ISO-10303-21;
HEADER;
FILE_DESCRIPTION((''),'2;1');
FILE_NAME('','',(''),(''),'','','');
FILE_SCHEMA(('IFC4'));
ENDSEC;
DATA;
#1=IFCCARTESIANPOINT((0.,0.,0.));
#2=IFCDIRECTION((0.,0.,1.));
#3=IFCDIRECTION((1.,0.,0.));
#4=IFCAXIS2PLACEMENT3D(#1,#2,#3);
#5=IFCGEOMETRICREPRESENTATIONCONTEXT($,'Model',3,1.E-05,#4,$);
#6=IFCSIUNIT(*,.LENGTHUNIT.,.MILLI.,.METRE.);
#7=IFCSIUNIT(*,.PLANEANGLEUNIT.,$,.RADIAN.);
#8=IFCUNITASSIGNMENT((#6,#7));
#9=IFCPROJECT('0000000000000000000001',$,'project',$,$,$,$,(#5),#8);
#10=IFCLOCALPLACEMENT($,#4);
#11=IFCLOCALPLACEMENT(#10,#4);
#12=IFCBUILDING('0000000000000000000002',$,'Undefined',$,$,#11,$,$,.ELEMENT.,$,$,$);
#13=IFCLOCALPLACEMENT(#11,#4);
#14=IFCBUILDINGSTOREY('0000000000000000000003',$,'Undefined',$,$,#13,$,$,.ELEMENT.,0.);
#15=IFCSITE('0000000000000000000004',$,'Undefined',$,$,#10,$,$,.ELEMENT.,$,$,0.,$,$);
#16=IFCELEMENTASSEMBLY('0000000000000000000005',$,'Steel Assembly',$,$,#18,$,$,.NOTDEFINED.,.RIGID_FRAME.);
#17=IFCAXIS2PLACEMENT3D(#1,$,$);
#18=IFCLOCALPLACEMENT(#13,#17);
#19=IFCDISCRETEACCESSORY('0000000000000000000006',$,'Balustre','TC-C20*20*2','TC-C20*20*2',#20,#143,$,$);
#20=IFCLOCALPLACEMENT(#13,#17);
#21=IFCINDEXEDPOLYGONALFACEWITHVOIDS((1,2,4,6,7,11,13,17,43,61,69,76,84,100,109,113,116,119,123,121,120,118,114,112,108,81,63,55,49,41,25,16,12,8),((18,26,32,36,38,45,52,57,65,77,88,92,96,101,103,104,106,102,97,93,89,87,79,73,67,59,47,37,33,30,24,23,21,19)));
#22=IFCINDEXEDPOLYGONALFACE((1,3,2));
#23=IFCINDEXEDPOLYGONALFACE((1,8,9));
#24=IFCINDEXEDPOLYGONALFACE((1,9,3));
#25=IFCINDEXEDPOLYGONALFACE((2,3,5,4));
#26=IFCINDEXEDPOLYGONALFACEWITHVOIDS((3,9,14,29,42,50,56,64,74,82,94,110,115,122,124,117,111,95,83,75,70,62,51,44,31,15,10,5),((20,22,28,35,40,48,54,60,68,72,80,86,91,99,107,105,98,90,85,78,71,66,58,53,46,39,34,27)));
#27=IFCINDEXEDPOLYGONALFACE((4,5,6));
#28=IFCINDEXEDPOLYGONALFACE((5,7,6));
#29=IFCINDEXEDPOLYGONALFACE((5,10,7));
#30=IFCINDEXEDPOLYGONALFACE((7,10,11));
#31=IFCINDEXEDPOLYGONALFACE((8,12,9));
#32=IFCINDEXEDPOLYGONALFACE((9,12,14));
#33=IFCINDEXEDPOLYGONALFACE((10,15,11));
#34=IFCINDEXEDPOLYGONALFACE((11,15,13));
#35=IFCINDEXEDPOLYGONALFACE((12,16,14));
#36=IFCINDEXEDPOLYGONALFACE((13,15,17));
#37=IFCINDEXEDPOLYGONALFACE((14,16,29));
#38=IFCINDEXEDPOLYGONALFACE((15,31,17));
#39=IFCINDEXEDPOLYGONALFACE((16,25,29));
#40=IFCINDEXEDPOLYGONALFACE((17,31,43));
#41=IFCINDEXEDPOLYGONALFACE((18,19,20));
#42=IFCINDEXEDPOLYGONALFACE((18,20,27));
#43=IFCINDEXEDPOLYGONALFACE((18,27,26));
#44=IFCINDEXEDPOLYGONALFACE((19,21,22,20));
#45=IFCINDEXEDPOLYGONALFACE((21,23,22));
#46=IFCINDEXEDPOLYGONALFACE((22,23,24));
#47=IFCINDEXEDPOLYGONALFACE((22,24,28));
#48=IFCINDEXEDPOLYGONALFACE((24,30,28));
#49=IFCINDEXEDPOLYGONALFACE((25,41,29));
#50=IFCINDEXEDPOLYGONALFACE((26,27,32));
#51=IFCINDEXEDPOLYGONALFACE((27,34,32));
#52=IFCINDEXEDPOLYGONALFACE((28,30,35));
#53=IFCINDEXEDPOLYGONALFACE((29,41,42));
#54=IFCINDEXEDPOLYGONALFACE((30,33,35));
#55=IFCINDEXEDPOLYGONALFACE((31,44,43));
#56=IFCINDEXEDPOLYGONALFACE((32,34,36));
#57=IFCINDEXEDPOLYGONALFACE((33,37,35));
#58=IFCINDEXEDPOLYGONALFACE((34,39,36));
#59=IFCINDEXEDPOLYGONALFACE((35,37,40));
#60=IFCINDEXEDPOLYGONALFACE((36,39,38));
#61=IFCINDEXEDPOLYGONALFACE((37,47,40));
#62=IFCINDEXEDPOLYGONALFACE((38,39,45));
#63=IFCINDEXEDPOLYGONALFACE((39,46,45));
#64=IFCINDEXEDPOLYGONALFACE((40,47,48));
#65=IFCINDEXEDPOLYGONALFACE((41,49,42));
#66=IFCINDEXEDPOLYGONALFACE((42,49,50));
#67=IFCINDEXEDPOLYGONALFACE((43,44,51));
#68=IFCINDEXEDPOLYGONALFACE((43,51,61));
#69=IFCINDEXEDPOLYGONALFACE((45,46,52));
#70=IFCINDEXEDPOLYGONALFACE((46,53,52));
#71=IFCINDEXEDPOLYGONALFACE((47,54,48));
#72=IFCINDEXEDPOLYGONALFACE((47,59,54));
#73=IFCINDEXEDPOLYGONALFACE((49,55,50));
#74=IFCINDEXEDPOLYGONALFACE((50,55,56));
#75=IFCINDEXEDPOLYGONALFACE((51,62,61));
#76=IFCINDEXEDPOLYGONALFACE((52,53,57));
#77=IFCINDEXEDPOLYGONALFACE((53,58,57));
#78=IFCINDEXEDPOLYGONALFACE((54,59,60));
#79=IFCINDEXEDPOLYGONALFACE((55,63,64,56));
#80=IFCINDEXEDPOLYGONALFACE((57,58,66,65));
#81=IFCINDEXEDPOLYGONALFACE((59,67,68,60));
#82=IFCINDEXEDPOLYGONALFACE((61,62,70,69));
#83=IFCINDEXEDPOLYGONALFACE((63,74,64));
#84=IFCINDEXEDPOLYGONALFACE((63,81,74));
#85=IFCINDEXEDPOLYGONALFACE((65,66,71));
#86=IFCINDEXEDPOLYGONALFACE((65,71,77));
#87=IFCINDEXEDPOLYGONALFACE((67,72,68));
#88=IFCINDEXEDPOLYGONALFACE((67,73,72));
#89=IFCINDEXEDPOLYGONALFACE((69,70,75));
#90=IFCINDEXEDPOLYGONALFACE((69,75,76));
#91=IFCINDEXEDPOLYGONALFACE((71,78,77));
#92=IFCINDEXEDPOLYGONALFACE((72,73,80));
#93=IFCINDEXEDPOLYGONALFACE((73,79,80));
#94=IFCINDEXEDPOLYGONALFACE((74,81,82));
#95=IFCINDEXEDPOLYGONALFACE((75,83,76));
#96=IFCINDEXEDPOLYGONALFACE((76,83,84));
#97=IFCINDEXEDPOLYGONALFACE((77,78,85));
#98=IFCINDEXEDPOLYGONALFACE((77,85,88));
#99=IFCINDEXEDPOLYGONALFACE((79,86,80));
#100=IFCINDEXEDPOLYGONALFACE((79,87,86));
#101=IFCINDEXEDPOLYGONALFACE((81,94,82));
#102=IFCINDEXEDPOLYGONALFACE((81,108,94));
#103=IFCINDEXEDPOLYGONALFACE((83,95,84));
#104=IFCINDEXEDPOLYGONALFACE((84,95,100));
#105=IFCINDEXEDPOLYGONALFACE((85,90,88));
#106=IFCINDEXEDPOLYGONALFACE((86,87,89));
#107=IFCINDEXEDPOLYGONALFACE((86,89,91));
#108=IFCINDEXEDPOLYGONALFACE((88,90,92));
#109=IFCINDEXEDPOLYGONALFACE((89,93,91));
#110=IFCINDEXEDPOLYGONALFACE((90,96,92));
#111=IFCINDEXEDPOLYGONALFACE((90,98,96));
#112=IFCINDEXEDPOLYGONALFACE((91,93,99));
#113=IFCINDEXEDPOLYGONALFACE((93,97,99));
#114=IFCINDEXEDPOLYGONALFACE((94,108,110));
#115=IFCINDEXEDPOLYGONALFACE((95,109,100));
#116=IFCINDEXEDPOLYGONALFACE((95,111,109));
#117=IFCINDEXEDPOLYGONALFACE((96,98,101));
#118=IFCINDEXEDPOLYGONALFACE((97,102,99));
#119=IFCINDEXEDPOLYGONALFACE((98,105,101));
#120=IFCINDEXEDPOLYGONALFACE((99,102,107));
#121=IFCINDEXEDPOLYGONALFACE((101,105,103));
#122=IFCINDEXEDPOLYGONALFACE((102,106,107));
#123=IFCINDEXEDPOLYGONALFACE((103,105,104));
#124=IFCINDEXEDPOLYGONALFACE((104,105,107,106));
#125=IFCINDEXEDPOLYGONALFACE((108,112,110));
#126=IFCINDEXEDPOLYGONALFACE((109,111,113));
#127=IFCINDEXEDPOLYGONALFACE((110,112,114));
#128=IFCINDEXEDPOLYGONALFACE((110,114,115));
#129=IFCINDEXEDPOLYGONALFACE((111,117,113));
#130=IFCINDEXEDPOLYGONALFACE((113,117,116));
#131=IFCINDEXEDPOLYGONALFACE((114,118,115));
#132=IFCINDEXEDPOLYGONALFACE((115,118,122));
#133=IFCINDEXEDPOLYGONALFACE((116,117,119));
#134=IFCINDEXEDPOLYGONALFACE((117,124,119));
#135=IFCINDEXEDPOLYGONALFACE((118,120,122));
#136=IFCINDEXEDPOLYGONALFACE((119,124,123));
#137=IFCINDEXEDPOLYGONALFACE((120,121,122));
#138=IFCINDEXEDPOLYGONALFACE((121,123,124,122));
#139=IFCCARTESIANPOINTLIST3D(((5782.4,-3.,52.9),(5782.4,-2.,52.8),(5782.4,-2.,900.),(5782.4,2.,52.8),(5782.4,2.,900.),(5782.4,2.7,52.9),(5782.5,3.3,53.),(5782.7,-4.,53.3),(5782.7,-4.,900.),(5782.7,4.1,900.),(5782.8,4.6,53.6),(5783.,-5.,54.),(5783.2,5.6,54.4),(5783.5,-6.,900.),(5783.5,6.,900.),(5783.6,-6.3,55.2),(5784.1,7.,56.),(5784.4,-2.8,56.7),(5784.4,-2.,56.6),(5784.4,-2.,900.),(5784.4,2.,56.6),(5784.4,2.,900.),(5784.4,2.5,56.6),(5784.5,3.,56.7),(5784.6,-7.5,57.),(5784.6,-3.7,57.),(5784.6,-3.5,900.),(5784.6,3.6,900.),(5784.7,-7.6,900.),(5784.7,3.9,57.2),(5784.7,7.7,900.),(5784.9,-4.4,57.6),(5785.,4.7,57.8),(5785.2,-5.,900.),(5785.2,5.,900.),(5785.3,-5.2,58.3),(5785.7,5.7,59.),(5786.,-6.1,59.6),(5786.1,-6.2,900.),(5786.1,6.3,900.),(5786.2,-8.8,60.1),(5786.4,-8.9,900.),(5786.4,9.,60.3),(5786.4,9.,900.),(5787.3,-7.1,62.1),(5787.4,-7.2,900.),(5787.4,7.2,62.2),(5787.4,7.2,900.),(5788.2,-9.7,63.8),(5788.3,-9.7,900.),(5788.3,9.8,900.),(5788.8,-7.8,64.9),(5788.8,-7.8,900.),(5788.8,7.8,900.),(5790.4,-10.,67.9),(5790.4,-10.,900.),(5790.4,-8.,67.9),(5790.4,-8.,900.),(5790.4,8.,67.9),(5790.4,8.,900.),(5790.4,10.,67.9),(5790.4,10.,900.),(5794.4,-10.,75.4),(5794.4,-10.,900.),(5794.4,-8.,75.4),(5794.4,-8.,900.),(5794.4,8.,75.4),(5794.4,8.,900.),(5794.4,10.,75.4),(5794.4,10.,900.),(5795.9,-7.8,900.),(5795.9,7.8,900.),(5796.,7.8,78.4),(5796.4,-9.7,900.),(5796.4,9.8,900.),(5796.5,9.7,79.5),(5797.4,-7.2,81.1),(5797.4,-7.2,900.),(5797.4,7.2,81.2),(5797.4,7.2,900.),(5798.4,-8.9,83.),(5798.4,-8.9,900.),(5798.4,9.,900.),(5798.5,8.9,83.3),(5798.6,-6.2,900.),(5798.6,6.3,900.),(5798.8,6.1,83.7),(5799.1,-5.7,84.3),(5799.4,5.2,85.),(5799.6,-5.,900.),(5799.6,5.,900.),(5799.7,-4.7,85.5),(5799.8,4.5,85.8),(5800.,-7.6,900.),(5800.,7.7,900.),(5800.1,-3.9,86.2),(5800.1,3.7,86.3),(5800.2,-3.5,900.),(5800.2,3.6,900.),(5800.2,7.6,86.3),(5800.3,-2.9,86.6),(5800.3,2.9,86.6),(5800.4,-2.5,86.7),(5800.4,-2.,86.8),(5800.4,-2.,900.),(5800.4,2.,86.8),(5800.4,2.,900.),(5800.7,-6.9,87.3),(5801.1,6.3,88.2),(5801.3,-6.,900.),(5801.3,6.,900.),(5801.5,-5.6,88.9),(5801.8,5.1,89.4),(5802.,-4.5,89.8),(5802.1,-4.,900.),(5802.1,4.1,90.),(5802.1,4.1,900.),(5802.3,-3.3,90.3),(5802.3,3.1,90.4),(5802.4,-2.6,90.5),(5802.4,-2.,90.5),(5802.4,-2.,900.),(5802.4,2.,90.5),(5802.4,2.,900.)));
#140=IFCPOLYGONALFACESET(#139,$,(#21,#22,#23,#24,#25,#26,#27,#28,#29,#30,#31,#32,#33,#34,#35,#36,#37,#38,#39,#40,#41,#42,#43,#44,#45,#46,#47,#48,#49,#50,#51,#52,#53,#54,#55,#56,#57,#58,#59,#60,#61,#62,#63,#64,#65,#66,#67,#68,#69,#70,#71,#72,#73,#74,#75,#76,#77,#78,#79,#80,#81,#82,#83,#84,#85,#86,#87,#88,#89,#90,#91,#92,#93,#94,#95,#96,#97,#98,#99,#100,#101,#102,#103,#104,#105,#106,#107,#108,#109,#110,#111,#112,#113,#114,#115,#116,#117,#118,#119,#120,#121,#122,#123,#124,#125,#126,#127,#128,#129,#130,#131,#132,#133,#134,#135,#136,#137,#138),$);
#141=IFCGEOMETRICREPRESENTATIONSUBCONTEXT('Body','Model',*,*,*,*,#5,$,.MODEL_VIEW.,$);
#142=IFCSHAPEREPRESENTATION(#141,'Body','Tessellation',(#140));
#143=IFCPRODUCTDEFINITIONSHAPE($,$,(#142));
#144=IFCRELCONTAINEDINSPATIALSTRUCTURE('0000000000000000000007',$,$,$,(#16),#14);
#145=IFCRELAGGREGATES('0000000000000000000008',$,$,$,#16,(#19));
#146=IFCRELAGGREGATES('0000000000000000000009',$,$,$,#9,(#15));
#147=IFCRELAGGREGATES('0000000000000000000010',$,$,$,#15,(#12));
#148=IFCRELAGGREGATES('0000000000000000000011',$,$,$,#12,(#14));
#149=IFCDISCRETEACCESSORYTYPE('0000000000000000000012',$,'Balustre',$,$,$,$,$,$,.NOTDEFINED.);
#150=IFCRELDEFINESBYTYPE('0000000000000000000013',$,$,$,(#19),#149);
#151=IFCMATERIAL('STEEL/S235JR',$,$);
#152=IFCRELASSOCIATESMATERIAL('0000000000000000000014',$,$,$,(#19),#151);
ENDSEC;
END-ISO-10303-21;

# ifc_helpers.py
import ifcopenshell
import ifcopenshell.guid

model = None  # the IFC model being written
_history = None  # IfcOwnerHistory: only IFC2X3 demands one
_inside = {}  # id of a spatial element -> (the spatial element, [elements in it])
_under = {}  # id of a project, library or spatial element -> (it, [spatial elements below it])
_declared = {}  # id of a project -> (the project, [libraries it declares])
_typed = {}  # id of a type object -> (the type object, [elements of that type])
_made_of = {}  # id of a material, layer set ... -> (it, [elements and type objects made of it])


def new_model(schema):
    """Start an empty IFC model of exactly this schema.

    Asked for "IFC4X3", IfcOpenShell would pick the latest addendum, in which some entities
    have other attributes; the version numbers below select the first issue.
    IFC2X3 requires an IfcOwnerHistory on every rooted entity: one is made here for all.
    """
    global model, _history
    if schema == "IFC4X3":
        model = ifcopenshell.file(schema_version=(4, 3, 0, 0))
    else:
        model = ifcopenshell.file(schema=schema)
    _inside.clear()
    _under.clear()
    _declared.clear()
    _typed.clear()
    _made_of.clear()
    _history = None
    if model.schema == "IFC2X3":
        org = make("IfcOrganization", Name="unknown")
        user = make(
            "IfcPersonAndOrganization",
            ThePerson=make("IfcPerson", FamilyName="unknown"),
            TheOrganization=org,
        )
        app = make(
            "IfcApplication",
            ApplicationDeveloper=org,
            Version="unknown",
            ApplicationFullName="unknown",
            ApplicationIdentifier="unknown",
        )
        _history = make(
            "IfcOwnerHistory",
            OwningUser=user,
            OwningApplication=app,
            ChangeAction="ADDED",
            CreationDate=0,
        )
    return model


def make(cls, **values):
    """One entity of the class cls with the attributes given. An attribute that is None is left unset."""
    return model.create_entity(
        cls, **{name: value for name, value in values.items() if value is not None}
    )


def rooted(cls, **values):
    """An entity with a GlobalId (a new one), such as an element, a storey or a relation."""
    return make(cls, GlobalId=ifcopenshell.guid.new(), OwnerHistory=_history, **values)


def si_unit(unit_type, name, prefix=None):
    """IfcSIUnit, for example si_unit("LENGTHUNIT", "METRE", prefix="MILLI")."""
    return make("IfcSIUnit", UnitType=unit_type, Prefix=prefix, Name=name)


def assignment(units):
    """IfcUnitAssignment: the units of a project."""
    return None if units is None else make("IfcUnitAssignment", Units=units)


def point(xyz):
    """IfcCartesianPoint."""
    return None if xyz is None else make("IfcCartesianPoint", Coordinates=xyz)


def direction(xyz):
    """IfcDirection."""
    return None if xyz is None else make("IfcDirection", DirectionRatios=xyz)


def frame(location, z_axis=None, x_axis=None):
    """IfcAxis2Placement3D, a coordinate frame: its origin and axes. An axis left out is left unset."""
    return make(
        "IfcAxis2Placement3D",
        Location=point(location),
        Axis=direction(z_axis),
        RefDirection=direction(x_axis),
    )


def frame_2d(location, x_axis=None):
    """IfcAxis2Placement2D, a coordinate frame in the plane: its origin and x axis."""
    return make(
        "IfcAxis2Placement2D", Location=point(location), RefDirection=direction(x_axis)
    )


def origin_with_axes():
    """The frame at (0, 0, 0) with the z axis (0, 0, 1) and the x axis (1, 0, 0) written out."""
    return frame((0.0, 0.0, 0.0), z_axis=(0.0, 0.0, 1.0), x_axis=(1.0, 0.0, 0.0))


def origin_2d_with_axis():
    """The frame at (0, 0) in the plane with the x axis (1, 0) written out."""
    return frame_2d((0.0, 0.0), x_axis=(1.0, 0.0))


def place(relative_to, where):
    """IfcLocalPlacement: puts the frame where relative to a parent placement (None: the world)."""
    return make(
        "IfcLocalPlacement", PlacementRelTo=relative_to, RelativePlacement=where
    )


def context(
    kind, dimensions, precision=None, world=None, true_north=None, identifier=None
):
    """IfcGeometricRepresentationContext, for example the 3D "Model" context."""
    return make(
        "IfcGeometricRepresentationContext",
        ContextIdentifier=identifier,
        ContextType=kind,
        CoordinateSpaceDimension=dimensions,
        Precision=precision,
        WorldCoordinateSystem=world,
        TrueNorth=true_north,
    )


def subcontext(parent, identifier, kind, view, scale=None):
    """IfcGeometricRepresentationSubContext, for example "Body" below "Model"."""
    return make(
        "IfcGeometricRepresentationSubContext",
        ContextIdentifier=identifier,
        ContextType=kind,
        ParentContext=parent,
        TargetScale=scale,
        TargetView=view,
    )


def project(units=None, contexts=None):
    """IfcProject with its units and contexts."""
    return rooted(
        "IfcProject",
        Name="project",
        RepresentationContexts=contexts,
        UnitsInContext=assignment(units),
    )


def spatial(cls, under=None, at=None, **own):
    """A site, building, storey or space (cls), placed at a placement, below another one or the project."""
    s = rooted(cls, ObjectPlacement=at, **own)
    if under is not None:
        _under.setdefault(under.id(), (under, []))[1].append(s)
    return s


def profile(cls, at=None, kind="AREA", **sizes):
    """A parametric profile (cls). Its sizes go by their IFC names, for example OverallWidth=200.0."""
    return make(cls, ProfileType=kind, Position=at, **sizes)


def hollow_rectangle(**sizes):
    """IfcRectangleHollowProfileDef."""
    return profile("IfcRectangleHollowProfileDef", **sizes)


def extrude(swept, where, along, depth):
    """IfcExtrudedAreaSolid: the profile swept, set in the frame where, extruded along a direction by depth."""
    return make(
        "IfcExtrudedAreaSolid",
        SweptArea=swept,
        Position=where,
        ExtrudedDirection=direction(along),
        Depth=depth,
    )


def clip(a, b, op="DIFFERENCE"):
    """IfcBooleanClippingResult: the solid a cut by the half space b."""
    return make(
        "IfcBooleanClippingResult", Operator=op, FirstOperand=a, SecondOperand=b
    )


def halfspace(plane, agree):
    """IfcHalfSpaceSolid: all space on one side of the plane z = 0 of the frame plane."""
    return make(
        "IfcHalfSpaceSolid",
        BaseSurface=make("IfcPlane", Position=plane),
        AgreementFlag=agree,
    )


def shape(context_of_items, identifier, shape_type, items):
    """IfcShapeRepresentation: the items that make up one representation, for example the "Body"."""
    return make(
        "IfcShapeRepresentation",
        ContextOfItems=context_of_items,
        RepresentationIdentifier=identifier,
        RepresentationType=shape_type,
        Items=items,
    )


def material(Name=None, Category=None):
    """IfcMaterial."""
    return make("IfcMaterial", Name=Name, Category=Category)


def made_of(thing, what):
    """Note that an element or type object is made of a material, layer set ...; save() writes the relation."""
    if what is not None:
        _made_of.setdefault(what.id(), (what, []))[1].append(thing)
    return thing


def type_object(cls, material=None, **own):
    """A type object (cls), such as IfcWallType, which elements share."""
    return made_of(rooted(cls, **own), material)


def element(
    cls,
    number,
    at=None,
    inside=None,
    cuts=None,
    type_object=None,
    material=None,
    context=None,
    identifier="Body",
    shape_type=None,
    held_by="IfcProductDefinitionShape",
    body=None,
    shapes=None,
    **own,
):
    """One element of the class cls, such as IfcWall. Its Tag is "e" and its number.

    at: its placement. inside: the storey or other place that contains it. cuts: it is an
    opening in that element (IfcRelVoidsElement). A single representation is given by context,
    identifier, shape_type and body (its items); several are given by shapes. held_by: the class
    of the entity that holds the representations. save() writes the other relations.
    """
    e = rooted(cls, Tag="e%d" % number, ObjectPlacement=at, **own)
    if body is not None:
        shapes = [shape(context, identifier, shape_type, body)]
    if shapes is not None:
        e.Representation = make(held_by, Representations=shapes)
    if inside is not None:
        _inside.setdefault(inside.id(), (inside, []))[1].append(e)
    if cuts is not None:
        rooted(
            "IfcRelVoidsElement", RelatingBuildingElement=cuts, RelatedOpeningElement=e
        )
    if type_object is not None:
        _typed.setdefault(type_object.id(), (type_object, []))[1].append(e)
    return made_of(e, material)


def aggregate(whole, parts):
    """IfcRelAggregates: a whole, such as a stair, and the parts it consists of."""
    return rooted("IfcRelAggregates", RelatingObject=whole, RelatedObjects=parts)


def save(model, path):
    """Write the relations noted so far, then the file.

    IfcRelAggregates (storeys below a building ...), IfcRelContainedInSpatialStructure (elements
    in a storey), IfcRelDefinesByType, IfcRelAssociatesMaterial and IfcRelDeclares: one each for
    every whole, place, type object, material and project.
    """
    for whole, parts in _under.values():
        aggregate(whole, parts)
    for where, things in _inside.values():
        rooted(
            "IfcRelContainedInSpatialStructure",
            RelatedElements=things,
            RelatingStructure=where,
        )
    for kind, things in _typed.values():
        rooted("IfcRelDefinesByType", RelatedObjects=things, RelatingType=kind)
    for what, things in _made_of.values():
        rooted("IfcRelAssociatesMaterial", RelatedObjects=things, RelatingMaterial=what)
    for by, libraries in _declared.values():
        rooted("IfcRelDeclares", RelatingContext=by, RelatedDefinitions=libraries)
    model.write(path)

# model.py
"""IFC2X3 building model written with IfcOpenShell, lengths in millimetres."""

from ifc_helpers import new_model, si_unit, frame, origin_with_axes, origin_2d_with_axis, place, context, subcontext, project, spatial, hollow_rectangle, extrude, clip, halfspace, material, type_object, element, aggregate, save


model = new_model("IFC2X3")

# Units and contexts
model_context = context("Model", 3, precision=1e-05, world=origin_with_axes())
body_context = subcontext(model_context, "Body", "Model", "MODEL_VIEW")
ifc_project = project(units=[si_unit("LENGTHUNIT", "METRE", prefix="MILLI"), si_unit("PLANEANGLEUNIT", "RADIAN")], contexts=[model_context])

# Site, building, storey
site_placement = place(None, origin_with_axes())
site = spatial("IfcSite", under=ifc_project, at=site_placement, Name="Undefined", CompositionType="ELEMENT", RefElevation=0.0)
building_placement = place(site_placement, origin_with_axes())
building = spatial("IfcBuilding", under=site, at=building_placement, Name="Undefined", CompositionType="ELEMENT")
storey_placement = place(building_placement, origin_with_axes())
storey = spatial("IfcBuildingStorey", under=building, at=storey_placement, Name="Undefined", CompositionType="ELEMENT", Elevation=0.0)

# Element assembly
ifc_material = material(Name="STEEL/S235JR")
assembly_1_placement = place(storey_placement, origin_with_axes())
assembly_1 = element("IfcElementAssembly", 1, at=assembly_1_placement, inside=storey, Name="Steel Assembly", AssemblyPlace="NOTDEFINED", PredefinedType="RIGID_FRAME")

# Discrete accessory
discrete_accessory_type_1 = type_object("IfcDiscreteAccessoryType", Name="Balustre")
discrete_accessory_1_placement = place(assembly_1_placement, frame((5792.4, 0.0, 900.0), z_axis=(-0.000011, 1.0, 0.0), x_axis=(0.0, 0.0, -1.0)))
discrete_accessory_1 = element("IfcDiscreteAccessory", 2, at=discrete_accessory_1_placement, type_object=discrete_accessory_type_1, material=ifc_material, Name="Balustre", Description="TC-C20*20*2", ObjectType="TC-C20*20*2", context=body_context, shape_type="Clipping", body=[
    clip(extrude(hollow_rectangle(XDim=20.0, YDim=20.0, WallThickness=2.0, InnerFilletRadius=6.0, OuterFilletRadius=8.0, at=origin_2d_with_axis()), frame((847.4, 0.0, 0.0), z_axis=(-1.0, 0.0, 0.0), x_axis=(0.0, -1.0, 0.0)), (0.0, 0.0, 1.0), 847.4), halfspace(frame((855.2, 14.2, 0.0), z_axis=(-0.46842, 0.883506, 0.000005), x_axis=(0.0, -0.000005, 1.0)), True)),
])
aggregate(assembly_1, [discrete_accessory_1])

save(model, "model.ifc")
